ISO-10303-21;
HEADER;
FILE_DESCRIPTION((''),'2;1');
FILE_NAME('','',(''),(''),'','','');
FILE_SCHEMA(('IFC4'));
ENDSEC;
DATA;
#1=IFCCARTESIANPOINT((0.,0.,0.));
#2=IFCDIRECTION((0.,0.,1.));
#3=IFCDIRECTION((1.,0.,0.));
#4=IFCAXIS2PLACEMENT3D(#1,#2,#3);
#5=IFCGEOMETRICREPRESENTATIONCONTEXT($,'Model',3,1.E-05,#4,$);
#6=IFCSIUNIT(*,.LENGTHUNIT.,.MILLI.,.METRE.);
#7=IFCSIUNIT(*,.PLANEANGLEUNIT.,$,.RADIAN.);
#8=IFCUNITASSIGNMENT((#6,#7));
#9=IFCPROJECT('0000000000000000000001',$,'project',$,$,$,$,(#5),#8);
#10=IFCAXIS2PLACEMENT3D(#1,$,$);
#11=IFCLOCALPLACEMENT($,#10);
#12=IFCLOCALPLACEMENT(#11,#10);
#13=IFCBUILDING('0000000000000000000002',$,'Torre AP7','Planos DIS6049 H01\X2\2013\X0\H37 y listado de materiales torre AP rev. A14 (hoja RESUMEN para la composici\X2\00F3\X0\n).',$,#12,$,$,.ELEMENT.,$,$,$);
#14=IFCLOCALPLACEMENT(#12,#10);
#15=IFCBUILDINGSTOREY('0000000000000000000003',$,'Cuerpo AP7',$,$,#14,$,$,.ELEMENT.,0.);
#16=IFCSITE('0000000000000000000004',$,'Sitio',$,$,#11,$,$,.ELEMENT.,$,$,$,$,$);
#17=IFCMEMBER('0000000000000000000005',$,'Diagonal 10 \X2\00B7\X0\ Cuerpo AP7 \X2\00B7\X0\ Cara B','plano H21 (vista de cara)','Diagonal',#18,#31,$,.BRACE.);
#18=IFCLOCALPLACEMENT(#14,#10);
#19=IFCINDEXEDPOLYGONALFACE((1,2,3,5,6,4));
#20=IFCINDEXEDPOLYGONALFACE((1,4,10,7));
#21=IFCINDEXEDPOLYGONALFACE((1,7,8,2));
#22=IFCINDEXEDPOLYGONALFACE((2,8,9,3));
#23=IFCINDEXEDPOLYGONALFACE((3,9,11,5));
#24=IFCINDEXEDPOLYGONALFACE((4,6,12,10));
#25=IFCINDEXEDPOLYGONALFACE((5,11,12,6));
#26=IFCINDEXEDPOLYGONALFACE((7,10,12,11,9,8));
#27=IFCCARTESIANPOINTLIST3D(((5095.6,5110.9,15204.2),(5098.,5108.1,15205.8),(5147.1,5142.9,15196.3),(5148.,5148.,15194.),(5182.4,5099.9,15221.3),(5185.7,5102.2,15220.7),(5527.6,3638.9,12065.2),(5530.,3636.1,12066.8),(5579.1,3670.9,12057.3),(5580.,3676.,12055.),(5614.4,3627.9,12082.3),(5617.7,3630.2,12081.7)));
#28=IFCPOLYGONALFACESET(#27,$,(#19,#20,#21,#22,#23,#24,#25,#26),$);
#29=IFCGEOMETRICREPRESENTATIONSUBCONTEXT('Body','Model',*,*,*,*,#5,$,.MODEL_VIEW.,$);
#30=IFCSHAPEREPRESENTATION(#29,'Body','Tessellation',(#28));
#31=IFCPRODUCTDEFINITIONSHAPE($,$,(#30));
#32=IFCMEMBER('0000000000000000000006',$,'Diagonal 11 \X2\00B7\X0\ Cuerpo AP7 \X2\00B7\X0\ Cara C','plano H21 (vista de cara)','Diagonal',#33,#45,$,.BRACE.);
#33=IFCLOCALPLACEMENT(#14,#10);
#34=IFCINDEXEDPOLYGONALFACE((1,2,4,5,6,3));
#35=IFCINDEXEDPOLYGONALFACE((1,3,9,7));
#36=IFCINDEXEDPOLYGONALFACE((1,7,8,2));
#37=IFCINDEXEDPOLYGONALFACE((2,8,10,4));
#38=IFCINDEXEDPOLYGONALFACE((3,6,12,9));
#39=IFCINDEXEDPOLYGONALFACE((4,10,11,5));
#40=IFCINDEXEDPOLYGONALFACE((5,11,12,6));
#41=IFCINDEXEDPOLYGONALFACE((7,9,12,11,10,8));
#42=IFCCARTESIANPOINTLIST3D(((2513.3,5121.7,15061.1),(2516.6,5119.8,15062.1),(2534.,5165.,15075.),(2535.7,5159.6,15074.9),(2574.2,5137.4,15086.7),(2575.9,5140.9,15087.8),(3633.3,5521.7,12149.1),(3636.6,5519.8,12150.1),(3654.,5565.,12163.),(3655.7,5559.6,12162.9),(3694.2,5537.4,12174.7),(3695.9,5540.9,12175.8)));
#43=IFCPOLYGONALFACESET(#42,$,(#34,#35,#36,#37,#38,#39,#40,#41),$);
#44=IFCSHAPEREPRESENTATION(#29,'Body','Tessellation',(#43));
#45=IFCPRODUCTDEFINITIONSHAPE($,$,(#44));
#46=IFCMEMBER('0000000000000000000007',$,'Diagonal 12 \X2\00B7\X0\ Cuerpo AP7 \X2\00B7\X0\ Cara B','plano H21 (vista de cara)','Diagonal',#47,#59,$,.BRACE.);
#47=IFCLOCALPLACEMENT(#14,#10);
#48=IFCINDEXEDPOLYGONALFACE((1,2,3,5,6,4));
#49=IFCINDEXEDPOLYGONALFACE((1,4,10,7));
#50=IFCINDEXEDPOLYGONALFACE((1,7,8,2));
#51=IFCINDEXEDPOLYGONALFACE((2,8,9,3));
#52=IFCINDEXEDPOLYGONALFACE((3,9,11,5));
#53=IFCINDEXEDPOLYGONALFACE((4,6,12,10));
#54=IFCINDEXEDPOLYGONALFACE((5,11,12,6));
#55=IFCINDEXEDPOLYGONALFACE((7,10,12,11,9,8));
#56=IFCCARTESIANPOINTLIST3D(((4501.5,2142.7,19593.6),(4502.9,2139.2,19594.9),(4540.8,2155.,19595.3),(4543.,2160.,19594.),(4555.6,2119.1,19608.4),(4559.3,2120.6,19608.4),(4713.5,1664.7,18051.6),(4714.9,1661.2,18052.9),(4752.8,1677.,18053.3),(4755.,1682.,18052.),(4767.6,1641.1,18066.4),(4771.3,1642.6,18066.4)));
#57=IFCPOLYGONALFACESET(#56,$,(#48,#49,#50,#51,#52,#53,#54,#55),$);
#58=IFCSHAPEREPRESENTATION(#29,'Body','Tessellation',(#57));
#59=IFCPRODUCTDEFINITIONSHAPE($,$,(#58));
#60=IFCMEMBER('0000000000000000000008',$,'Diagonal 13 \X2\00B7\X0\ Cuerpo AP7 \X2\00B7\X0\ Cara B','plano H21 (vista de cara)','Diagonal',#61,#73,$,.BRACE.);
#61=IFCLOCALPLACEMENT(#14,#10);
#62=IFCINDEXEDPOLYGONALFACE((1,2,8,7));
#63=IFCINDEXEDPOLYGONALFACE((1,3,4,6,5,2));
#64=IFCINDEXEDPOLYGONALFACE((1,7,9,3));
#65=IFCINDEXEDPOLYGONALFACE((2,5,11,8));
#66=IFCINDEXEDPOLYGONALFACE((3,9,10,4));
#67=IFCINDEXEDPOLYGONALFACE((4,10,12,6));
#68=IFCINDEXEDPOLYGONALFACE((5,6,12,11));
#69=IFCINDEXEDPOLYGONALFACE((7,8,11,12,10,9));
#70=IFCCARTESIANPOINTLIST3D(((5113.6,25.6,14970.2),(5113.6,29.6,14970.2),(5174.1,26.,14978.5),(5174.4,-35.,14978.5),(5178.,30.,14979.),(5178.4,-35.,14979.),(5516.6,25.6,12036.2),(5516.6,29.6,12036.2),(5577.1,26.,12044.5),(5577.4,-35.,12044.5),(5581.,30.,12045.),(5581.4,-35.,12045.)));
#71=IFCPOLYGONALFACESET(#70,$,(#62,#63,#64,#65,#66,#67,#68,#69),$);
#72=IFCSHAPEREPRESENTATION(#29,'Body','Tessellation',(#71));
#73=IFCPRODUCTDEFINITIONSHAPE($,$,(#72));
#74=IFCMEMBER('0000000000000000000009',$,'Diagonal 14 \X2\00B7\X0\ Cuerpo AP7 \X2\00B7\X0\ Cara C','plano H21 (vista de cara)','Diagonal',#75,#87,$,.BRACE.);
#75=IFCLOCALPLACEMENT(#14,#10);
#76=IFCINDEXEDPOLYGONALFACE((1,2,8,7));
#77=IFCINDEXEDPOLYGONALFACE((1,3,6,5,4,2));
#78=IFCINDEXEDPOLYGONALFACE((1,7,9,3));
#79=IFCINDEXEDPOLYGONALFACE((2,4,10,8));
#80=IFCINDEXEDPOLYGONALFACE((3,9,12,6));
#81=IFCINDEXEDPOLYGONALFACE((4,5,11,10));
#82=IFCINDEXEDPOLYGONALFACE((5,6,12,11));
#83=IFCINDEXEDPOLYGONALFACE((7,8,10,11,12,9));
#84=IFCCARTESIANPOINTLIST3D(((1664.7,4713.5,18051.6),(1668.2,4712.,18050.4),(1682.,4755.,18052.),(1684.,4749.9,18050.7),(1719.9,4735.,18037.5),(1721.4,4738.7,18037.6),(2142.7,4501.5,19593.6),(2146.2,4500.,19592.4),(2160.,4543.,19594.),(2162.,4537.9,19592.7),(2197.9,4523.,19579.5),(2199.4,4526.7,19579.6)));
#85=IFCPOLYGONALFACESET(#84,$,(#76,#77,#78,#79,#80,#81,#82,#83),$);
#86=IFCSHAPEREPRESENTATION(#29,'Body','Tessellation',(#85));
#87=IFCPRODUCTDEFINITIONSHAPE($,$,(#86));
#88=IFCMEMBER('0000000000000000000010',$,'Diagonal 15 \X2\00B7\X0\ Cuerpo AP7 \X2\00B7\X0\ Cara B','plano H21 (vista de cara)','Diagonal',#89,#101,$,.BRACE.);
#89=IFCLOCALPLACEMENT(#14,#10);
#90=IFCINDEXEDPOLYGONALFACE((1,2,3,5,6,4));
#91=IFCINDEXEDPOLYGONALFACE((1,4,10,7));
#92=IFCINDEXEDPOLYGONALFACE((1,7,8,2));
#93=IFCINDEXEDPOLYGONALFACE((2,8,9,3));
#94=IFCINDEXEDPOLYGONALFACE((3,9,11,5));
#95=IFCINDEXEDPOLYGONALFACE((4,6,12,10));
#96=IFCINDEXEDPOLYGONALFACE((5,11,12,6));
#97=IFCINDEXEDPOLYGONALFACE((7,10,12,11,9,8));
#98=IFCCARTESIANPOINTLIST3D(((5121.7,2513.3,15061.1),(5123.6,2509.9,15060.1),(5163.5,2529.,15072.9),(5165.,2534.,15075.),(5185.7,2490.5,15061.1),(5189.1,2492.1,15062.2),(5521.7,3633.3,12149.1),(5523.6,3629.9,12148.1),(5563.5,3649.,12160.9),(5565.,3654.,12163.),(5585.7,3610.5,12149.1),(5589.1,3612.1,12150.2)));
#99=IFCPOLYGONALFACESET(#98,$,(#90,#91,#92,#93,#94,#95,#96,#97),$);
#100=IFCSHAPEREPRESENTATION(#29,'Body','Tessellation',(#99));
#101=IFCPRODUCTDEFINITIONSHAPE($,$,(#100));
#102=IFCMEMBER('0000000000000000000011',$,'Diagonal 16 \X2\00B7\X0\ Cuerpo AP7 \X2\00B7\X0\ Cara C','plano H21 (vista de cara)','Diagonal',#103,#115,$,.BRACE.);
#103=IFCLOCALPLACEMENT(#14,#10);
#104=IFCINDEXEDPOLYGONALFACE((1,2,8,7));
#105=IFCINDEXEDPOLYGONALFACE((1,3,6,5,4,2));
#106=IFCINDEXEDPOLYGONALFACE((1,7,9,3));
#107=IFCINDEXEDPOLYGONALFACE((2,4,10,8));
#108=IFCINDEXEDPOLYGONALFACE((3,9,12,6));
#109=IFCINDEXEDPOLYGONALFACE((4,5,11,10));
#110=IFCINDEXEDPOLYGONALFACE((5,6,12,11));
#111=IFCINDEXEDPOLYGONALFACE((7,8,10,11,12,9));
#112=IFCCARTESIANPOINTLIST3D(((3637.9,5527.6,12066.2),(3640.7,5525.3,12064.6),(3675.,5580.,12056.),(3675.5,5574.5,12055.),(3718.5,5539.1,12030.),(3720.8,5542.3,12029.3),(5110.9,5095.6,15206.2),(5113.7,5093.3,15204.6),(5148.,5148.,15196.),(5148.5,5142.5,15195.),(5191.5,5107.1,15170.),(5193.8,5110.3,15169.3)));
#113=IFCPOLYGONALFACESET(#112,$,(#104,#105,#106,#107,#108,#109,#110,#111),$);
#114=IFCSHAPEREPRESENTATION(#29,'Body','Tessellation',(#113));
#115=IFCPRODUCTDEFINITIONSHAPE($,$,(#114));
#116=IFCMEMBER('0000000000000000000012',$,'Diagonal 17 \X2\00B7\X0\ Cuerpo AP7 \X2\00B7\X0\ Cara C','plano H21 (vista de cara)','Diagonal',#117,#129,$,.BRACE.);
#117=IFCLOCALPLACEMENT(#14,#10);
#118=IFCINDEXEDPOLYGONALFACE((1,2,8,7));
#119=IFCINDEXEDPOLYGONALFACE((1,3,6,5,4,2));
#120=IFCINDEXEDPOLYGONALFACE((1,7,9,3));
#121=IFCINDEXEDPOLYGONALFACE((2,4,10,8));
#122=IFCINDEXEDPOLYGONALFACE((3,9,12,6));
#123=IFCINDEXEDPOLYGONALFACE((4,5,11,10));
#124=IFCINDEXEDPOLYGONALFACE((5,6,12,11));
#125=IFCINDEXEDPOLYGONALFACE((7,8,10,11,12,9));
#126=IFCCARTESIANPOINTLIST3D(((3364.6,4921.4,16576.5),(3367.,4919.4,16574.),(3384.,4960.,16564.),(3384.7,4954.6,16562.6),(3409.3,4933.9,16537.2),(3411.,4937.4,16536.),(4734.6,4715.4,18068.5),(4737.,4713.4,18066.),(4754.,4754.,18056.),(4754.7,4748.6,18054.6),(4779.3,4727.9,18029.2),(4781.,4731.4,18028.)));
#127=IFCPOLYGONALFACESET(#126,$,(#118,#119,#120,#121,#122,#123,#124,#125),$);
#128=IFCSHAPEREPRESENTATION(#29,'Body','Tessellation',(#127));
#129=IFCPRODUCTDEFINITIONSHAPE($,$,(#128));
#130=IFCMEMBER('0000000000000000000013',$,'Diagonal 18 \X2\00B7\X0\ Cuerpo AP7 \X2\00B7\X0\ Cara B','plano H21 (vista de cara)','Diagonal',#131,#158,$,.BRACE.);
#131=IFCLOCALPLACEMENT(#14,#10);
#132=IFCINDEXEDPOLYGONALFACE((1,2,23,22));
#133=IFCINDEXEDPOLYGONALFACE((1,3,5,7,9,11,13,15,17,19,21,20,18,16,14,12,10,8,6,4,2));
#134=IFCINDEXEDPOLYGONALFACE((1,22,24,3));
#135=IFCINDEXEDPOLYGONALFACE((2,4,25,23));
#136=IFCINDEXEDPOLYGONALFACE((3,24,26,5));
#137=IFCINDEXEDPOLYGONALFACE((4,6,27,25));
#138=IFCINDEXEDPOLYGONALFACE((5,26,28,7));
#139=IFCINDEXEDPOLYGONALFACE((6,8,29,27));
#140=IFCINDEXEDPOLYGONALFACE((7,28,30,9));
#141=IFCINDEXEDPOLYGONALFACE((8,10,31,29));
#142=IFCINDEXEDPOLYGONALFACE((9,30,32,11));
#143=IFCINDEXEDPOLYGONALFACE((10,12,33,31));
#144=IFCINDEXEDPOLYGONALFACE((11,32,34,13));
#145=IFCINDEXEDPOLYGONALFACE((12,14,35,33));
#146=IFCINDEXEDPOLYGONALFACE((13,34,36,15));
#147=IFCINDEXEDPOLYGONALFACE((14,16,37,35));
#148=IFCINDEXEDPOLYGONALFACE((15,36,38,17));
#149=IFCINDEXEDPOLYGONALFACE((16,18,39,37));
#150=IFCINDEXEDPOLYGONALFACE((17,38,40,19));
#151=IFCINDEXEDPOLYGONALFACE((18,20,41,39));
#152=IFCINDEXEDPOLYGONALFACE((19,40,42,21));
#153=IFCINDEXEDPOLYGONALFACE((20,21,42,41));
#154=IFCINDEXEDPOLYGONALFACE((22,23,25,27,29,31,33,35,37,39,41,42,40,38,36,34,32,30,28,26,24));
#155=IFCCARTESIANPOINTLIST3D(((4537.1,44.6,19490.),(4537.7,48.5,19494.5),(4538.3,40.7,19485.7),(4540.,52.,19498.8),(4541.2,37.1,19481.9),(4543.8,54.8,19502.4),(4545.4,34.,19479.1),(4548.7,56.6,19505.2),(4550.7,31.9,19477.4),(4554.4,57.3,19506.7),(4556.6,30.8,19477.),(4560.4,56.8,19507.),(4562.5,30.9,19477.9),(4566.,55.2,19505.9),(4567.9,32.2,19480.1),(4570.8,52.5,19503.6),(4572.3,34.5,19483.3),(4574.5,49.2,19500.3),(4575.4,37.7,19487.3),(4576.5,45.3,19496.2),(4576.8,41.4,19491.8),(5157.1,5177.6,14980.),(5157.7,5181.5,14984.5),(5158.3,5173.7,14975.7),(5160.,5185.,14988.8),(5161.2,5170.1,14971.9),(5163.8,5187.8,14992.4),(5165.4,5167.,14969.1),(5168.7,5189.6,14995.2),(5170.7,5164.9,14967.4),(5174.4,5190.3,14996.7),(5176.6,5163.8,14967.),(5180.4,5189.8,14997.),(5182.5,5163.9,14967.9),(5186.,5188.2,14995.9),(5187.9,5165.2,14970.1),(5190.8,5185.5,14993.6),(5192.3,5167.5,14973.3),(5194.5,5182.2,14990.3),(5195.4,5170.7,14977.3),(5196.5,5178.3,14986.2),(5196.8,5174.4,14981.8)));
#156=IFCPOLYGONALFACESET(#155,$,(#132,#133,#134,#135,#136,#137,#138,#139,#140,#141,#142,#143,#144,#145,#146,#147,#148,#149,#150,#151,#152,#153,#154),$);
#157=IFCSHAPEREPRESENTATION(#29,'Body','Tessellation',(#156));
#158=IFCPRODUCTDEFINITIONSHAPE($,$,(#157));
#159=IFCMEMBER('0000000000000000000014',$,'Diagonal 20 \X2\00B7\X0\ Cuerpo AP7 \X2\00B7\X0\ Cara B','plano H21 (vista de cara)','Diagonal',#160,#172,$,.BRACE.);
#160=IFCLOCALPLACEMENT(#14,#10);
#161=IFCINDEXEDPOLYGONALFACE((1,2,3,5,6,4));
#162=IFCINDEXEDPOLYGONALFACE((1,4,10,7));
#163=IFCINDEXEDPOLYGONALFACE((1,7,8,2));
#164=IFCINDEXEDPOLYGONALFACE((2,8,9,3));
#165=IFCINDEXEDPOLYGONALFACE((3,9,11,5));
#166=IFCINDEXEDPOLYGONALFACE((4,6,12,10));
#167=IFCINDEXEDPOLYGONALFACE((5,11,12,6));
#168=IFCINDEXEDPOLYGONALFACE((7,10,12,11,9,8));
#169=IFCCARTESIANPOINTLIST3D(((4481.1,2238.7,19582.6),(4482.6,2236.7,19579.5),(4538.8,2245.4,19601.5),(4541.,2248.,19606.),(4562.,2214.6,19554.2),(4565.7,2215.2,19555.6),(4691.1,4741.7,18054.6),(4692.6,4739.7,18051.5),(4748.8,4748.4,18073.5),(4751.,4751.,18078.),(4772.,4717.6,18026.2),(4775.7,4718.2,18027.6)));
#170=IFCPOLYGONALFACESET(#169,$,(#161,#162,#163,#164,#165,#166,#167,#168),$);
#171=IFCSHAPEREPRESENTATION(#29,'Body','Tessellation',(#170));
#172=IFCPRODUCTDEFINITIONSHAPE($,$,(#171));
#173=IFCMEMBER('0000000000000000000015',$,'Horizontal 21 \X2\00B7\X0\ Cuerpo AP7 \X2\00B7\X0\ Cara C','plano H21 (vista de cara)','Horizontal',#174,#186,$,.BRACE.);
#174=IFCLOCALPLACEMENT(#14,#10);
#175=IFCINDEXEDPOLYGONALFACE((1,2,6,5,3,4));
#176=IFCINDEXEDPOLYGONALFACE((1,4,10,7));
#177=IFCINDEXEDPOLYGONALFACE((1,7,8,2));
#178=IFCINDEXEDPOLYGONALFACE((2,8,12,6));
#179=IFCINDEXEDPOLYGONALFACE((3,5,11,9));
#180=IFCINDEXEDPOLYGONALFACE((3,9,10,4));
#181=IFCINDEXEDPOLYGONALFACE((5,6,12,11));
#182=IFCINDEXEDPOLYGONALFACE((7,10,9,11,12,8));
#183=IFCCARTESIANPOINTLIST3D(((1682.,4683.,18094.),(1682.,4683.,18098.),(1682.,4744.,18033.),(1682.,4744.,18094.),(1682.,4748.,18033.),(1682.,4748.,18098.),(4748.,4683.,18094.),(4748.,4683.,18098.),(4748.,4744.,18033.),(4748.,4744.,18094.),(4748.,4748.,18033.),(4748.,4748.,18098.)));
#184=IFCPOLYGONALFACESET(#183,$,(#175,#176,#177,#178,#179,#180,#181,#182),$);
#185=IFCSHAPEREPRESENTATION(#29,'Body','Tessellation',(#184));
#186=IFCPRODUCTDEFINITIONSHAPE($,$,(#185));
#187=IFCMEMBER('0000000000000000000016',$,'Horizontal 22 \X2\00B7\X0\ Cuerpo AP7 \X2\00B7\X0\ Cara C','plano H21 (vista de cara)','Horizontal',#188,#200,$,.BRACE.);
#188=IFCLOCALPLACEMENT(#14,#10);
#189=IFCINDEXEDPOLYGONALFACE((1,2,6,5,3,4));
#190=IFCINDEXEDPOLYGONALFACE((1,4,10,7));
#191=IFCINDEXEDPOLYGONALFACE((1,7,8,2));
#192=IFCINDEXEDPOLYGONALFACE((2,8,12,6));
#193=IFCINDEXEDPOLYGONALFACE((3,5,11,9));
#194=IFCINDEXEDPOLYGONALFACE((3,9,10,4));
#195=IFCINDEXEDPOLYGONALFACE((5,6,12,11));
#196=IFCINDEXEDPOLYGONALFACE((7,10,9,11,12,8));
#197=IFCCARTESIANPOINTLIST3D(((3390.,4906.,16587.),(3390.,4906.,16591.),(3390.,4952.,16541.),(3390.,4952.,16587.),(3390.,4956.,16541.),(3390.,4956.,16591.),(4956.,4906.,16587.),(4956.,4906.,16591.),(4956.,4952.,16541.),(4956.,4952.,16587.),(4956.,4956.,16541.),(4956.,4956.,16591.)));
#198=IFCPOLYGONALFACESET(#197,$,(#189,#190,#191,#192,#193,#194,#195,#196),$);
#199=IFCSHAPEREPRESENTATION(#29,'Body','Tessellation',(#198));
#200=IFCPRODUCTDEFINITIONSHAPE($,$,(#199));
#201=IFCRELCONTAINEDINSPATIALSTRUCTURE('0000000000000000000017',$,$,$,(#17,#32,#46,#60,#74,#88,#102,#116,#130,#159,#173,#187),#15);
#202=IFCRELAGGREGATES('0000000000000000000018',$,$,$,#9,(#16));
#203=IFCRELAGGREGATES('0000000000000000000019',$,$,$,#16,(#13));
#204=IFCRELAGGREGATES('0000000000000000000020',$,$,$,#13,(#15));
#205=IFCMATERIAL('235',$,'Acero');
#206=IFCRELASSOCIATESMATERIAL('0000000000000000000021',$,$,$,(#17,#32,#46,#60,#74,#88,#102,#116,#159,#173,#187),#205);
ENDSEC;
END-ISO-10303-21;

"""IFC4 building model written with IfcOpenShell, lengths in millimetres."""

from ifc_helpers import new_model, si_unit, frame, frame_2d, origin, origin_with_axes, place, context, subcontext, project, spatial, circle, l_section, extrude, material, element, save


model = new_model("IFC4")

# Units and contexts
model_context = context("Model", 3, precision=1e-05, world=origin_with_axes())
body_context = subcontext(model_context, "Body", "Model", "MODEL_VIEW")
ifc_project = project(units=[si_unit("LENGTHUNIT", "METRE", prefix="MILLI"), si_unit("PLANEANGLEUNIT", "RADIAN")], contexts=[model_context])

# Site, building, storey
site_placement = place(None, origin())
site = spatial("IfcSite", under=ifc_project, at=site_placement, Name="Sitio", CompositionType="ELEMENT")
building_placement = place(site_placement, origin())
building = spatial("IfcBuilding", under=site, at=building_placement, Name="Torre AP7", Description="Planos DIS6049 H01–H37 y listado de materiales torre AP rev. A14 (hoja RESUMEN para la composición).", CompositionType="ELEMENT")
storey_placement = place(building_placement, origin())
storey = spatial("IfcBuildingStorey", under=building, at=storey_placement, Name="Cuerpo AP7", CompositionType="ELEMENT", Elevation=0.0)

# Members
ifc_material_1 = material(Name="235", Category="Acero")
member_1_placement = place(storey_placement, frame((5580.0, 3676.0, 12055.0), z_axis=(-0.123647, 0.421316, 0.898445), x_axis=(-0.805624, -0.571243, 0.157006)))
element("IfcMember", 1, at=member_1_placement, inside=storey, material=ifc_material_1, Name="Diagonal 10 · Cuerpo AP7 · Cara B", Description="plano H21 (vista de cara)", ObjectType="Diagonal", PredefinedType="BRACE", context=body_context, shape_type="SweptSolid", body=[
    extrude(l_section(Depth=65.0, Width=65.0, Thickness=4.0, at=frame_2d((32.5, 32.5))), None, (0.0, 0.0, 1.0), 3493.8),
])
member_2_placement = place(storey_placement, frame((3654.0, 5565.0, 12163.0), z_axis=(-0.356065, -0.127166, 0.925768), x_axis=(-0.414588, -0.866358, -0.278462)))
element("IfcMember", 2, at=member_2_placement, inside=storey, material=ifc_material_1, Name="Diagonal 11 · Cuerpo AP7 · Cara C", Description="plano H21 (vista de cara)", ObjectType="Diagonal", PredefinedType="BRACE", context=body_context, shape_type="SweptSolid", body=[
    extrude(l_section(Depth=50.0, Width=50.0, Thickness=4.0, at=frame_2d((25.0, 25.0))), None, (0.0, 0.0, 1.0), 3145.5),
])
member_3_placement = place(storey_placement, frame((4755.0, 1682.0, 18052.0), z_axis=(-0.130201, 0.293567, 0.94703), x_axis=(-0.923169, -0.384316, -0.007788)))
element("IfcMember", 3, at=member_3_placement, inside=storey, material=ifc_material_1, Name="Diagonal 12 · Cuerpo AP7 · Cara B", Description="plano H21 (vista de cara)", ObjectType="Diagonal", PredefinedType="BRACE", context=body_context, shape_type="SweptSolid", body=[
    extrude(l_section(Depth=45.0, Width=45.0, Thickness=4.0, at=frame_2d((22.5, 22.5))), None, (0.0, 0.0, 1.0), 1628.2),
])
member_4_placement = place(storey_placement, frame((5581.0, 30.0, 12045.0), z_axis=(-0.136077, 0.0, 0.990698), x_axis=(-0.990683, -0.005629, -0.136075)))
element("IfcMember", 4, at=member_4_placement, inside=storey, material=ifc_material_1, Name="Diagonal 13 · Cuerpo AP7 · Cara B", Description="plano H21 (vista de cara)", ObjectType="Diagonal", PredefinedType="BRACE", context=body_context, shape_type="SweptSolid", body=[
    extrude(l_section(Depth=65.0, Width=65.0, Thickness=4.0, at=frame_2d((32.5, 32.5))), None, (0.0, 0.0, 1.0), 2961.5),
])
member_5_placement = place(storey_placement, frame((1682.0, 4755.0, 18052.0), z_axis=(0.293567, -0.130201, 0.94703), x_axis=(-0.384316, -0.923169, -0.007788)))
element("IfcMember", 5, at=member_5_placement, inside=storey, material=ifc_material_1, Name="Diagonal 14 · Cuerpo AP7 · Cara C", Description="plano H21 (vista de cara)", ObjectType="Diagonal", PredefinedType="BRACE", context=body_context, shape_type="SweptSolid", body=[
    extrude(l_section(Depth=45.0, Width=45.0, Thickness=4.0, at=frame_2d((22.5, 22.5))), None, (0.0, 0.0, 1.0), 1628.2),
])
member_6_placement = place(storey_placement, frame((5565.0, 3654.0, 12163.0), z_axis=(-0.127166, -0.356065, 0.925768), x_axis=(-0.866358, -0.414588, -0.278462)))
element("IfcMember", 6, at=member_6_placement, inside=storey, material=ifc_material_1, Name="Diagonal 15 · Cuerpo AP7 · Cara B", Description="plano H21 (vista de cara)", ObjectType="Diagonal", PredefinedType="BRACE", context=body_context, shape_type="SweptSolid", body=[
    extrude(l_section(Depth=50.0, Width=50.0, Thickness=4.0, at=frame_2d((25.0, 25.0))), None, (0.0, 0.0, 1.0), 3145.5),
])
member_7_placement = place(storey_placement, frame((3675.0, 5580.0, 12056.0), z_axis=(0.421443, -0.1236, 0.898392), x_axis=(-0.571147, -0.805677, 0.157085)))
element("IfcMember", 7, at=member_7_placement, inside=storey, material=ifc_material_1, Name="Diagonal 16 · Cuerpo AP7 · Cara C", Description="plano H21 (vista de cara)", ObjectType="Diagonal", PredefinedType="BRACE", context=body_context, shape_type="SweptSolid", body=[
    extrude(l_section(Depth=65.0, Width=65.0, Thickness=4.0, at=frame_2d((32.5, 32.5))), None, (0.0, 0.0, 1.0), 3495.1),
])
member_8_placement = place(storey_placement, frame((3384.0, 4960.0, 16564.0), z_axis=(0.67288, -0.101178, 0.7328), x_axis=(-0.431654, -0.858174, 0.27787)))
element("IfcMember", 8, at=member_8_placement, inside=storey, material=ifc_material_1, Name="Diagonal 17 · Cuerpo AP7 · Cara C", Description="plano H21 (vista de cara)", ObjectType="Diagonal", PredefinedType="BRACE", context=body_context, shape_type="SweptSolid", body=[
    extrude(l_section(Depth=45.0, Width=45.0, Thickness=4.0, at=frame_2d((22.5, 22.5))), None, (0.0, 0.0, 1.0), 2036.0),
])
member_9_placement = place(storey_placement, frame((5177.0, 5177.0, 14982.0), z_axis=(-0.090367, -0.748151, 0.657346), x_axis=(-0.934337, -0.164794, -0.316003)))
element("IfcMember", 9, at=member_9_placement, inside=storey, Name="Diagonal 18 · Cuerpo AP7 · Cara B", Description="plano H21 (vista de cara)", ObjectType="Diagonal", PredefinedType="BRACE", context=body_context, shape_type="SweptSolid", body=[
    extrude(circle(Radius=20.0), None, (0.0, 0.0, 1.0), 6860.9),
])
member_10_placement = place(storey_placement, frame((4751.0, 4751.0, 18078.0), z_axis=(-0.071427, -0.851346, 0.519719), x_axis=(-0.922089, -0.142318, -0.359857)))
element("IfcMember", 10, at=member_10_placement, inside=storey, material=ifc_material_1, Name="Diagonal 20 · Cuerpo AP7 · Cara B", Description="plano H21 (vista de cara)", ObjectType="Diagonal", PredefinedType="BRACE", context=body_context, shape_type="SweptSolid", body=[
    extrude(l_section(Depth=65.0, Width=65.0, Thickness=4.0, at=frame_2d((32.5, 32.5))), None, (0.0, 0.0, 1.0), 2940.0),
])
member_11_placement = place(storey_placement, frame((1682.0, 4748.0, 18098.0), z_axis=(1.0, 0.0, 0.0), x_axis=(0.0, -1.0, 0.0)))
element("IfcMember", 11, at=member_11_placement, inside=storey, material=ifc_material_1, Name="Horizontal 21 · Cuerpo AP7 · Cara C", Description="plano H21 (vista de cara)", ObjectType="Horizontal", PredefinedType="BRACE", context=body_context, shape_type="SweptSolid", body=[
    extrude(l_section(Depth=65.0, Width=65.0, Thickness=4.0, at=frame_2d((32.5, 32.5))), None, (0.0, 0.0, 1.0), 3066.0),
])
member_12_placement = place(storey_placement, frame((3390.0, 4956.0, 16591.0), z_axis=(1.0, 0.0, 0.0), x_axis=(0.0, -1.0, 0.0)))
element("IfcMember", 12, at=member_12_placement, inside=storey, material=ifc_material_1, Name="Horizontal 22 · Cuerpo AP7 · Cara C", Description="plano H21 (vista de cara)", ObjectType="Horizontal", PredefinedType="BRACE", context=body_context, shape_type="SweptSolid", body=[
    extrude(l_section(Depth=50.0, Width=50.0, Thickness=4.0, at=frame_2d((25.0, 25.0))), None, (0.0, 0.0, 1.0), 1566.0),
])

save(model, "model.ifc")
